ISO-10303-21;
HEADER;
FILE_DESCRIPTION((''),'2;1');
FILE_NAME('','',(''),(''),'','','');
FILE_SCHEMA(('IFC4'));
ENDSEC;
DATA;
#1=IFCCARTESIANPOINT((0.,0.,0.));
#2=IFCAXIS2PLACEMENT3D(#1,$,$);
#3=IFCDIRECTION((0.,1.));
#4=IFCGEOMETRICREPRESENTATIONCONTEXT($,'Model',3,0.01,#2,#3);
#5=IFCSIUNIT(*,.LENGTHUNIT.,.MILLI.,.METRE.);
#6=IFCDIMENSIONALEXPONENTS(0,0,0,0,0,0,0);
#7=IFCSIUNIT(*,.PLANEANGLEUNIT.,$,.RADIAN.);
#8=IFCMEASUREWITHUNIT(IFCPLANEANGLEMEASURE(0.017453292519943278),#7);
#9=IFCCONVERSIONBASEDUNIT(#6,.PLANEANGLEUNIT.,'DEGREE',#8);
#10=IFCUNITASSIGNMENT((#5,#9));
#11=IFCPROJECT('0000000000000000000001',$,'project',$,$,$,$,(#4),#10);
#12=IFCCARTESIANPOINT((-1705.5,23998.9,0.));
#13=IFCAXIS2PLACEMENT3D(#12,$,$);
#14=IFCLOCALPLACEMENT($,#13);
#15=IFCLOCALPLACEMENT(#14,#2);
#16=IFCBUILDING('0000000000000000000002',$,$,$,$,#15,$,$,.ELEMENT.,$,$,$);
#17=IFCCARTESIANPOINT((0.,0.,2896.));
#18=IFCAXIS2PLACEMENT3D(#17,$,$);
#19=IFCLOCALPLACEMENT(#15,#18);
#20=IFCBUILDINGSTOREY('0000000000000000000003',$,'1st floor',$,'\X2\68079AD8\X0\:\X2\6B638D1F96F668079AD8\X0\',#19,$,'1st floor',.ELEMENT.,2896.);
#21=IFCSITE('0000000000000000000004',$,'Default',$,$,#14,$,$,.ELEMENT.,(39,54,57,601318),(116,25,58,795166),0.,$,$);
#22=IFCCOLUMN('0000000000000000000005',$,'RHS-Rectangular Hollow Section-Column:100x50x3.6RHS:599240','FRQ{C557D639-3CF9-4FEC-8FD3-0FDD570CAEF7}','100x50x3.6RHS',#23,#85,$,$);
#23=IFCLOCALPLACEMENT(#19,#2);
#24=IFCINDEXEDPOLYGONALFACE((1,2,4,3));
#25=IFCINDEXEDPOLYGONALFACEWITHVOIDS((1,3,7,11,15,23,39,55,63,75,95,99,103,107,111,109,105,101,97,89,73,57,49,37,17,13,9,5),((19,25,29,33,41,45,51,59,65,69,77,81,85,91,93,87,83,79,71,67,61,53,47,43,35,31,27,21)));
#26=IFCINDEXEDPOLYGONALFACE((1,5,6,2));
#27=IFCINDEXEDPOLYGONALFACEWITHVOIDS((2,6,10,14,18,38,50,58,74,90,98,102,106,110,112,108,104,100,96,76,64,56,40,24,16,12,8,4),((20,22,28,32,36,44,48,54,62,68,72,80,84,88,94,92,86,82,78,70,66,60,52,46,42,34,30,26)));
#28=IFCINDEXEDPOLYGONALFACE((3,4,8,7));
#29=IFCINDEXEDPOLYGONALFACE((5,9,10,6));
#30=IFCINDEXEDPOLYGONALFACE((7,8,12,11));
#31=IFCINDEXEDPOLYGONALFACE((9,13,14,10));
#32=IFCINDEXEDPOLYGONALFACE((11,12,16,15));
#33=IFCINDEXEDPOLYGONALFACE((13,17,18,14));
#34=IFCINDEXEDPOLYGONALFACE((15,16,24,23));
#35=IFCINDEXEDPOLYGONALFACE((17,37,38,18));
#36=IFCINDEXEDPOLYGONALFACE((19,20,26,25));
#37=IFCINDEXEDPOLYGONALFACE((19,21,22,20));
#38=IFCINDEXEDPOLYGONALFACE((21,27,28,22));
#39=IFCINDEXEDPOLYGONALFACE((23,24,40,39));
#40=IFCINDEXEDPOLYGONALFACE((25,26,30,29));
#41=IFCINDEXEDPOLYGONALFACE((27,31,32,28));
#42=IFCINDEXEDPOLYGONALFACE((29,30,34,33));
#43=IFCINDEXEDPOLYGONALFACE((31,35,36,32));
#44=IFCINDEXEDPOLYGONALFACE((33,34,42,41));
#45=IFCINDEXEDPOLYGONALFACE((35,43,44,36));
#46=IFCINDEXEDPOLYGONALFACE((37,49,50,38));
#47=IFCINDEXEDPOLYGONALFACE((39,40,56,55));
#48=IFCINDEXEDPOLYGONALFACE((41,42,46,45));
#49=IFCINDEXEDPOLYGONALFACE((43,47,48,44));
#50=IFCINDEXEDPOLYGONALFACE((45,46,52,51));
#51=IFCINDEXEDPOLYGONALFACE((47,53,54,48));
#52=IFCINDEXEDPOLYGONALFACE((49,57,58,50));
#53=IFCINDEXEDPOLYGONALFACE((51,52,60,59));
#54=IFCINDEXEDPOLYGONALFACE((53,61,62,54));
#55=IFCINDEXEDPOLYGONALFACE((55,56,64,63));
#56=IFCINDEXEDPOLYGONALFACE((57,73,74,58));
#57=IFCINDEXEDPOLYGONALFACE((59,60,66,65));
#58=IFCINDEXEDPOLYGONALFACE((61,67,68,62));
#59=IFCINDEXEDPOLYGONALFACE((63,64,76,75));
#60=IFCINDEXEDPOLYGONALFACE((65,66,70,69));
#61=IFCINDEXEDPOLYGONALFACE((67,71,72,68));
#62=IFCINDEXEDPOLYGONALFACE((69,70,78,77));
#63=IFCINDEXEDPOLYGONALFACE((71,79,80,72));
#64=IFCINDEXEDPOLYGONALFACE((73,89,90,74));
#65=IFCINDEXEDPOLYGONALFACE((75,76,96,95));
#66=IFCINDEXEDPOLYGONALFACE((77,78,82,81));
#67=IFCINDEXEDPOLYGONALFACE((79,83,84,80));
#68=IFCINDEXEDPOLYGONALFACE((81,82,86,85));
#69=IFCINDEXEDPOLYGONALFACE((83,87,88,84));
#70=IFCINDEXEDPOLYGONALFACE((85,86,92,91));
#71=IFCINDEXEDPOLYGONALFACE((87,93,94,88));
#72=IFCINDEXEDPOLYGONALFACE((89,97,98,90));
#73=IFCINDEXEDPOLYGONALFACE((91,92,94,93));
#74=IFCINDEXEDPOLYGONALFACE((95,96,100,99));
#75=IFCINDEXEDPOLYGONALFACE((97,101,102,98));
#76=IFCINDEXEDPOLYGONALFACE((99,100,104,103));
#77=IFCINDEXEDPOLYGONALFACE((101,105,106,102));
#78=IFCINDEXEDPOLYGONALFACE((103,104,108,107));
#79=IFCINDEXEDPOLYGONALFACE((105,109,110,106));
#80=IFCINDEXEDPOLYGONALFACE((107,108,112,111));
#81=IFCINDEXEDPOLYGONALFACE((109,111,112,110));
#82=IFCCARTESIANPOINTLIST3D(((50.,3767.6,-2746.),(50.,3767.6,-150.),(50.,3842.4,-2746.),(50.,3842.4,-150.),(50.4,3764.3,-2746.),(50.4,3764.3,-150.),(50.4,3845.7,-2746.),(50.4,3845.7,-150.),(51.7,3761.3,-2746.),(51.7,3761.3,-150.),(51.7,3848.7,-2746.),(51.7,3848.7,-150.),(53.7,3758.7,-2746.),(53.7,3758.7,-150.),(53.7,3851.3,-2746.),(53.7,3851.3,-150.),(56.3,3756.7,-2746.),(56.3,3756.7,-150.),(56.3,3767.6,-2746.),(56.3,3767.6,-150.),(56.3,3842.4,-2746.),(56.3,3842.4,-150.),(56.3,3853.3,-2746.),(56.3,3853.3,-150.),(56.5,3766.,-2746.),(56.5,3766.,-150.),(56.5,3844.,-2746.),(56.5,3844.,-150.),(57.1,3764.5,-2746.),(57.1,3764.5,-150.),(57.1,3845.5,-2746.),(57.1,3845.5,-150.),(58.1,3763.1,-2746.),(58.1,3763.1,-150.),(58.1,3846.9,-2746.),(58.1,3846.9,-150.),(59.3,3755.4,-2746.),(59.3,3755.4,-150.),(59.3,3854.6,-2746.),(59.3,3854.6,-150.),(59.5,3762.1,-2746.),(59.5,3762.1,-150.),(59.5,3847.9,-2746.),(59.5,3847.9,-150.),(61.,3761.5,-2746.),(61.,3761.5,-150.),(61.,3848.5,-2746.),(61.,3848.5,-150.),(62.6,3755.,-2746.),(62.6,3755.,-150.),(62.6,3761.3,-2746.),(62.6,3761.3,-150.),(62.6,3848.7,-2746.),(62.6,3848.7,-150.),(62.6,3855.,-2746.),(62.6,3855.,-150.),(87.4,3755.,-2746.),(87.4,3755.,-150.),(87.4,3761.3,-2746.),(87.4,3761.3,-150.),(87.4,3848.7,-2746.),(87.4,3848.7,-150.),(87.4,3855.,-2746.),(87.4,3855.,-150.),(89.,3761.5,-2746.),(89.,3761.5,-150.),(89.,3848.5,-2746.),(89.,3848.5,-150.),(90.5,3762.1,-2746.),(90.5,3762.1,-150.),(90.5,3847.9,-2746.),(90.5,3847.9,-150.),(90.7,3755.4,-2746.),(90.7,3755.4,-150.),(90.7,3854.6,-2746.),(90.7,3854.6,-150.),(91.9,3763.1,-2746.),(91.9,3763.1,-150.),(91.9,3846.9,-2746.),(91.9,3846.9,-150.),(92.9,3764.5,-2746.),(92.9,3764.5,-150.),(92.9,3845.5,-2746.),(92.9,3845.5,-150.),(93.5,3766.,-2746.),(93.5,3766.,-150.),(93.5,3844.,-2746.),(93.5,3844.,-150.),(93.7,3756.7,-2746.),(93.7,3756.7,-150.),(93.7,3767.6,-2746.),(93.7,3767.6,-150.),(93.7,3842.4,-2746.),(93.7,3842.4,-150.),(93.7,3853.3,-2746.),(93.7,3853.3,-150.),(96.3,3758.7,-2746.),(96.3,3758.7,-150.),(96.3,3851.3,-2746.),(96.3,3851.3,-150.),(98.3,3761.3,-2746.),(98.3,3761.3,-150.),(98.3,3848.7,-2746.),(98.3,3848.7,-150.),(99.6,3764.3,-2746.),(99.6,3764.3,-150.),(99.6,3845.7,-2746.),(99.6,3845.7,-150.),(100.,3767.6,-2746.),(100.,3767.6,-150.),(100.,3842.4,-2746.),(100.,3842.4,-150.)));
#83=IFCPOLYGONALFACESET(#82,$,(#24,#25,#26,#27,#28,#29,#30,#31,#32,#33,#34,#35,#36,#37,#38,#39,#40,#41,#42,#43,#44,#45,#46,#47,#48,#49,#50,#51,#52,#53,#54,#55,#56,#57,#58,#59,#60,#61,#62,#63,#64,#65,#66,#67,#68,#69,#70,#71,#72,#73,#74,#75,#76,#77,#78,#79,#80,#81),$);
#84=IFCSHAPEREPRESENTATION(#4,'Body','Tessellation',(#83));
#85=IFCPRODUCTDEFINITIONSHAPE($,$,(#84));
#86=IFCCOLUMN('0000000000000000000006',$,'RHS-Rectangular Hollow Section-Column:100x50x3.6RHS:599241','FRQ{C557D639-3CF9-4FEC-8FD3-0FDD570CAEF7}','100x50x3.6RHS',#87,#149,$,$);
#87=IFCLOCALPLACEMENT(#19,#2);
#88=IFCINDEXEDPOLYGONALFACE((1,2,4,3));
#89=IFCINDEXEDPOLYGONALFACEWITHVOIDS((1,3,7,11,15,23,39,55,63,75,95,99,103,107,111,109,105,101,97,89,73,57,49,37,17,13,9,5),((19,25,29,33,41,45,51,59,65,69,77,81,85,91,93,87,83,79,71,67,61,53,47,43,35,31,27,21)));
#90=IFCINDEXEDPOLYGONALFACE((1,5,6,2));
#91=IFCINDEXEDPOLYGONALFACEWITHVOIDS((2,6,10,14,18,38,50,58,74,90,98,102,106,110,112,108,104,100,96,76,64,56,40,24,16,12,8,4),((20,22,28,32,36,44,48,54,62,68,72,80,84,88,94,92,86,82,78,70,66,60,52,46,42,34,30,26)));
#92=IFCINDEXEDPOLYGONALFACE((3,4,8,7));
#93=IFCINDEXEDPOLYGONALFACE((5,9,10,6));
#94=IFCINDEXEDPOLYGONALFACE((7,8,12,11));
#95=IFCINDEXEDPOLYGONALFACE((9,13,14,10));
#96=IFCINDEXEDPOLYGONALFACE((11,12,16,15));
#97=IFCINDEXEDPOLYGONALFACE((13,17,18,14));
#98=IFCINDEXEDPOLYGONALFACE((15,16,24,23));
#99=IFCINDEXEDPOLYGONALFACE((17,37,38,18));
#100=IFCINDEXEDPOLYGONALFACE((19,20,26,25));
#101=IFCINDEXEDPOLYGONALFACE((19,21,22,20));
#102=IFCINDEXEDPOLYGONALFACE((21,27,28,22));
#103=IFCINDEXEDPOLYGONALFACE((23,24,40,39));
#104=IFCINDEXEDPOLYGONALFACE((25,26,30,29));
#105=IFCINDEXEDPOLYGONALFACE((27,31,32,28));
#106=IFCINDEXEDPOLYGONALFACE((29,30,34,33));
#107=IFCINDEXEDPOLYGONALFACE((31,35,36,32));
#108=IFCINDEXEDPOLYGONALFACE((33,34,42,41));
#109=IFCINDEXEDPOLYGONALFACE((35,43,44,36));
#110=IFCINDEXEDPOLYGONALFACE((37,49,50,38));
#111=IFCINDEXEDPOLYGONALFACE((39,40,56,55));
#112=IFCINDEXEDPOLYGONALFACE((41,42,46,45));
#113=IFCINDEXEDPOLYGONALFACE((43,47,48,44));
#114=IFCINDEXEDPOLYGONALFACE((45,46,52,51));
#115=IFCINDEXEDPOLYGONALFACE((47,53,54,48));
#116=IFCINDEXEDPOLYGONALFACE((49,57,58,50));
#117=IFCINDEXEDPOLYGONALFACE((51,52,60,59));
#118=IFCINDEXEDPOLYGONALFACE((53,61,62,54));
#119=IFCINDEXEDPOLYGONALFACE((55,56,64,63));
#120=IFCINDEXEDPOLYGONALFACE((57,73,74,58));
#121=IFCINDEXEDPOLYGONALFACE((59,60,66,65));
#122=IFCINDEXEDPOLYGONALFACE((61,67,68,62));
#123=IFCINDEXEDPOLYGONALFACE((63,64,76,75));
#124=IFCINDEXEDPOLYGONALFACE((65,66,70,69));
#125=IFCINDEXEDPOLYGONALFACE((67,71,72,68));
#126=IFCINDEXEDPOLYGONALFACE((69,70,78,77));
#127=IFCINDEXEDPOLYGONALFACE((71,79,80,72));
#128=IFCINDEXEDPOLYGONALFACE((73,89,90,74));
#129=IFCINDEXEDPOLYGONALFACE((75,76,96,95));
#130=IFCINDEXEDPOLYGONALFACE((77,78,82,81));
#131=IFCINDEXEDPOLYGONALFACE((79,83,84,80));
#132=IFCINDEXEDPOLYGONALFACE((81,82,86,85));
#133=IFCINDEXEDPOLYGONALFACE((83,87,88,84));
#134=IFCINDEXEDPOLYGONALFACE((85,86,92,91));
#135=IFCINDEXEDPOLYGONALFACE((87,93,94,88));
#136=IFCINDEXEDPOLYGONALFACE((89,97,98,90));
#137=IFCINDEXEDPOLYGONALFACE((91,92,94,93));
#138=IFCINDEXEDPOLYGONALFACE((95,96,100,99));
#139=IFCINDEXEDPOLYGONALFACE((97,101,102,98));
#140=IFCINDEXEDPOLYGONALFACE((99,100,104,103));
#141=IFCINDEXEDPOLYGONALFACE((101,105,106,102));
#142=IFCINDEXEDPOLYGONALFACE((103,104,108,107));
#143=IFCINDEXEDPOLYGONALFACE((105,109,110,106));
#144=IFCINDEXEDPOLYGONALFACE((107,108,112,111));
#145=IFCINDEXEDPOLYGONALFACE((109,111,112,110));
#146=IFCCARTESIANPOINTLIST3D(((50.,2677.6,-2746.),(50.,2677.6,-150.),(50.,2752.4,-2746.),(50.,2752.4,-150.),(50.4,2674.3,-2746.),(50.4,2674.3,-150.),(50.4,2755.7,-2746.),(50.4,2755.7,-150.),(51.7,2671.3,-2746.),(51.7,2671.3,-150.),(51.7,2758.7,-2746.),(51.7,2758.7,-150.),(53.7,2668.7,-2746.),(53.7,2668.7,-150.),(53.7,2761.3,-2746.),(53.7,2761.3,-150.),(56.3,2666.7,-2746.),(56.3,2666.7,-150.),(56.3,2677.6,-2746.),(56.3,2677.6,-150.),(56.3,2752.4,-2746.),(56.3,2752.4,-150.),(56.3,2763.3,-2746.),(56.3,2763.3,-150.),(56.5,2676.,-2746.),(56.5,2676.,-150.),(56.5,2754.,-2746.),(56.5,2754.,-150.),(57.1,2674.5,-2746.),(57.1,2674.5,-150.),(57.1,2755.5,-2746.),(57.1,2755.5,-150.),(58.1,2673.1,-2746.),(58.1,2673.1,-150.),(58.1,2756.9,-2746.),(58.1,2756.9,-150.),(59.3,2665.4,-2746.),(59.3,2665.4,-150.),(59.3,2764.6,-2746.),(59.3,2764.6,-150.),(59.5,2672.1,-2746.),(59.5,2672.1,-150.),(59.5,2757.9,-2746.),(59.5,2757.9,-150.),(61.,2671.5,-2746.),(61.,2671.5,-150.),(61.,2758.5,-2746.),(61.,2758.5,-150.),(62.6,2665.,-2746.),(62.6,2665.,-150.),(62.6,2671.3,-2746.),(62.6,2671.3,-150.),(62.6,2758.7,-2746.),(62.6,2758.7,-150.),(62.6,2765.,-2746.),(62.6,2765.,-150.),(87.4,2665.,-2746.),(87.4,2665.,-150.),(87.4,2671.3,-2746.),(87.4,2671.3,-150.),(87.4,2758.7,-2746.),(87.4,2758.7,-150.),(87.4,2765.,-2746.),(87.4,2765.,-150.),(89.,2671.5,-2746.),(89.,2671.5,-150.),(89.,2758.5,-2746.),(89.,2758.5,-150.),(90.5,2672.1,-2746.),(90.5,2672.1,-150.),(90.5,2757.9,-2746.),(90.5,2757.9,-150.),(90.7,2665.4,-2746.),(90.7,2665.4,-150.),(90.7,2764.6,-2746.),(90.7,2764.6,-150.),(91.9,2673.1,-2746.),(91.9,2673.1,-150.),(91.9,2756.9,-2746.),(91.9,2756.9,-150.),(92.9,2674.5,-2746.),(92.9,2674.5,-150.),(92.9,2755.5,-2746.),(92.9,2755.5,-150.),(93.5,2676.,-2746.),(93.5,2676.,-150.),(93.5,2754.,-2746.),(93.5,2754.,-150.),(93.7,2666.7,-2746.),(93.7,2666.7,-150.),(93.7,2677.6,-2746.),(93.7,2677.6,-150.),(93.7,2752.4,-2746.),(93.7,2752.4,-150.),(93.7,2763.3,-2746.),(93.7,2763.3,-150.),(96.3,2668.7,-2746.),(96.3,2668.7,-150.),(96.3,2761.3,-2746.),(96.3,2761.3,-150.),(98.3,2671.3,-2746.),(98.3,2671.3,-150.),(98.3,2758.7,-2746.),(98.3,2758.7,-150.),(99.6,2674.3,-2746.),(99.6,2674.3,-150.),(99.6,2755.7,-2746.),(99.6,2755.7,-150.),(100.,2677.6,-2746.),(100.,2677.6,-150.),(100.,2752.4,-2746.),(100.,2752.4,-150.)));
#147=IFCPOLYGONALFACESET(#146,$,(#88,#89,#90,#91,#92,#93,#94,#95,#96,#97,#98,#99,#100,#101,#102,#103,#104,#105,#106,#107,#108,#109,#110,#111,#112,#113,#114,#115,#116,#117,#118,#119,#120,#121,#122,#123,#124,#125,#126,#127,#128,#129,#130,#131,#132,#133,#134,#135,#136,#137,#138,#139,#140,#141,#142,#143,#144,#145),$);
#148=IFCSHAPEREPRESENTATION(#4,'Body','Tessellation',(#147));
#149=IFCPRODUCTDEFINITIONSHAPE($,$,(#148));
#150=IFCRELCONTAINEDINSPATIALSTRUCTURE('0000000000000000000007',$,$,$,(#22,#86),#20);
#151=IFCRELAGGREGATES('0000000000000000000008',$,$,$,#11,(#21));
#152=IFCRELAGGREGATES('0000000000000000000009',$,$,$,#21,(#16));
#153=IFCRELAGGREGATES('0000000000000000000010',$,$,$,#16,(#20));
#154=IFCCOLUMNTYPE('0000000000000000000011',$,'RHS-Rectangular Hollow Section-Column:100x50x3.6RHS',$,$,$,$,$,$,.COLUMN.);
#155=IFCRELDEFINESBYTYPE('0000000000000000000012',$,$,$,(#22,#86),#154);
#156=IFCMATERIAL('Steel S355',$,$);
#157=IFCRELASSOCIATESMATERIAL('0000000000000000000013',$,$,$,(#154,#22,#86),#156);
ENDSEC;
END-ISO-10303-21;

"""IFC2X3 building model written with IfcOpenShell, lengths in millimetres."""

from ifc_helpers import new_model, entity, si_unit, converted_unit, point, direction, frame, frame_2d, origin, origin_2d, place, context, project, spatial, circle_curve, line_curve, trimmed, segment, composite_curve, hollow_rectangle, outline, extrude, clip, halfspace, material, type_object, element, save


model = new_model("IFC2X3")

# Units and contexts
model_context = context("Model", 3, precision=0.01, world=origin(), true_north=direction((0.0, 1.0)))
ifc_project = project(units=[si_unit("LENGTHUNIT", "METRE", prefix="MILLI"), converted_unit("PLANEANGLEUNIT", "DEGREE", entity("IfcPlaneAngleMeasure", 0.017453292519943278), si_unit("PLANEANGLEUNIT", "RADIAN"), dimensions=[0, 0, 0, 0, 0, 0, 0])], contexts=[model_context])

# Site, building, storey
site_placement = place(None, frame((-1705.5, 23998.9, 0.0)))
site = spatial("IfcSite", under=ifc_project, at=site_placement, Name="Default", CompositionType="ELEMENT", RefLatitude=(39, 54, 57, 601318), RefLongitude=(116, 25, 58, 795166), RefElevation=0.0)
building_placement = place(site_placement, origin())
building = spatial("IfcBuilding", under=site, at=building_placement, CompositionType="ELEMENT")
storey_placement = place(building_placement, frame((0.0, 0.0, 2896.0)))
storey = spatial("IfcBuildingStorey", under=building, at=storey_placement, Name="1st floor", ObjectType="标高:正负零标高", LongName="1st floor", CompositionType="ELEMENT", Elevation=2896.0)

# Shared definitions
ifc_material_1 = material(Name="Steel S355")

# Columns, openings
column_type_1 = type_object("IfcColumnType", Name="RHS-Rectangular Hollow Section-Column:100x50x3.6RHS", PredefinedType="COLUMN", material=ifc_material_1)
column_1_placement = place(storey_placement, frame((75.0, 3805.0, -19.1)))
column_1 = element("IfcColumn", 1, at=column_1_placement, inside=storey, type_object=column_type_1, material=ifc_material_1, Name="RHS-Rectangular Hollow Section-Column:100x50x3.6RHS:599240", Description="FRQ{C557D639-3CF9-4FEC-8FD3-0FDD570CAEF7}", ObjectType="100x50x3.6RHS", context=model_context, shape_type="Clipping", body=[
    clip(clip(extrude(hollow_rectangle(XDim=50.0, YDim=100.0, WallThickness=6.3, InnerFilletRadius=6.3, OuterFilletRadius=12.6, at=origin_2d()), origin(), (0.0, 0.0, -1.0), 2782.8), halfspace(frame((-75.0, -3805.0, -55.9), z_axis=(0.0, 0.0, -1.0), x_axis=(-1.0, 0.0, 0.0)), True)), halfspace(frame((-75.0, -3805.0, -2726.9), z_axis=(0.0, 0.0, 1.0), x_axis=(1.0, 0.0, 0.0)), True)),
])
opening_1_placement = place(column_1_placement, frame((0.0, -150.1, -130.9), z_axis=(0.0, 1.0, 0.0), x_axis=(-1.0, 0.0, 0.0)))
element("IfcOpeningElement", 2, at=opening_1_placement, cuts=column_1, ObjectType="Opening", context=model_context, shape_type="SweptSolid", body=[
    extrude(outline(composite_curve([segment(trimmed(circle_curve(frame_2d((43.0, 32.0), x_axis=(1.0, 0.0)), 32.0), [point((43.0, 0.0))], [point((75.0, 32.0))], True, "CARTESIAN"), True, "CONTINUOUS"), segment(trimmed(line_curve((75.0, 32.0), (0.0, 1.0), 86.0), [point((75.0, 32.0))], [point((75.0, 118.0))], True, "CARTESIAN"), True, "CONTINUOUS"), segment(trimmed(circle_curve(frame_2d((43.0, 118.0), x_axis=(1.0, 0.0)), 32.0), [point((75.0, 118.0))], [point((43.0, 150.0))], True, "CARTESIAN"), True, "CONTINUOUS"), segment(trimmed(line_curve((43.0, 150.0), (-1.0, 0.0), 86.0), [point((43.0, 150.0))], [point((-43.0, 150.0))], True, "CARTESIAN"), True, "CONTINUOUS"), segment(trimmed(circle_curve(frame_2d((-43.0, 118.0), x_axis=(1.0, 0.0)), 32.0), [point((-43.0, 150.0))], [point((-75.0, 118.0))], True, "CARTESIAN"), True, "CONTINUOUS"), segment(trimmed(line_curve((-75.0, 118.0), (0.0, -1.0), 86.0), [point((-75.0, 118.0))], [point((-75.0, 32.0))], True, "CARTESIAN"), True, "CONTINUOUS"), segment(trimmed(circle_curve(frame_2d((-43.0, 32.0), x_axis=(1.0, 0.0)), 32.0), [point((-75.0, 32.0))], [point((-43.0, 0.0))], True, "CARTESIAN"), True, "CONTINUOUS"), segment(trimmed(line_curve((-43.0, 0.0), (1.0, 0.0), 86.0), [point((-43.0, 0.0))], [point((43.0, 0.0))], True, "CARTESIAN"), True, "CONTINUOUS")], self_intersect="UNKNOWN")), origin(), (0.0, 0.0, 1.0), 300.2),
])
column_2_placement = place(storey_placement, frame((75.0, 2715.0, -19.1)))
column_2 = element("IfcColumn", 3, at=column_2_placement, inside=storey, type_object=column_type_1, material=ifc_material_1, Name="RHS-Rectangular Hollow Section-Column:100x50x3.6RHS:599241", Description="FRQ{C557D639-3CF9-4FEC-8FD3-0FDD570CAEF7}", ObjectType="100x50x3.6RHS", context=model_context, shape_type="Clipping", body=[
    clip(clip(extrude(hollow_rectangle(XDim=50.0, YDim=100.0, WallThickness=6.3, InnerFilletRadius=6.3, OuterFilletRadius=12.6, at=origin_2d()), origin(), (0.0, 0.0, -1.0), 2782.8), halfspace(frame((-75.0, -2715.0, -55.9), z_axis=(0.0, 0.0, -1.0), x_axis=(-1.0, 0.0, 0.0)), True)), halfspace(frame((-75.0, -2715.0, -2726.9), z_axis=(0.0, 0.0, 1.0), x_axis=(1.0, 0.0, 0.0)), True)),
])
opening_2_placement = place(column_2_placement, frame((0.0, -150.1, -130.9), z_axis=(0.0, 1.0, 0.0), x_axis=(-1.0, 0.0, 0.0)))
element("IfcOpeningElement", 4, at=opening_2_placement, cuts=column_2, ObjectType="Opening", context=model_context, shape_type="SweptSolid", body=[
    extrude(outline(composite_curve([segment(trimmed(circle_curve(frame_2d((43.0, 32.0), x_axis=(1.0, 0.0)), 32.0), [point((43.0, 0.0))], [point((75.0, 32.0))], True, "CARTESIAN"), True, "CONTINUOUS"), segment(trimmed(line_curve((75.0, 32.0), (0.0, 1.0), 86.0), [point((75.0, 32.0))], [point((75.0, 118.0))], True, "CARTESIAN"), True, "CONTINUOUS"), segment(trimmed(circle_curve(frame_2d((43.0, 118.0), x_axis=(1.0, 0.0)), 32.0), [point((75.0, 118.0))], [point((43.0, 150.0))], True, "CARTESIAN"), True, "CONTINUOUS"), segment(trimmed(line_curve((43.0, 150.0), (-1.0, 0.0), 86.0), [point((43.0, 150.0))], [point((-43.0, 150.0))], True, "CARTESIAN"), True, "CONTINUOUS"), segment(trimmed(circle_curve(frame_2d((-43.0, 118.0), x_axis=(1.0, 0.0)), 32.0), [point((-43.0, 150.0))], [point((-75.0, 118.0))], True, "CARTESIAN"), True, "CONTINUOUS"), segment(trimmed(line_curve((-75.0, 118.0), (0.0, -1.0), 86.0), [point((-75.0, 118.0))], [point((-75.0, 32.0))], True, "CARTESIAN"), True, "CONTINUOUS"), segment(trimmed(circle_curve(frame_2d((-43.0, 32.0), x_axis=(1.0, 0.0)), 32.0), [point((-75.0, 32.0))], [point((-43.0, 0.0))], True, "CARTESIAN"), True, "CONTINUOUS"), segment(trimmed(line_curve((-43.0, 0.0), (1.0, 0.0), 86.0), [point((-43.0, 0.0))], [point((43.0, 0.0))], True, "CARTESIAN"), True, "CONTINUOUS")], self_intersect="UNKNOWN")), origin(), (0.0, 0.0, 1.0), 300.2),
])

save(model, "model.ifc")
